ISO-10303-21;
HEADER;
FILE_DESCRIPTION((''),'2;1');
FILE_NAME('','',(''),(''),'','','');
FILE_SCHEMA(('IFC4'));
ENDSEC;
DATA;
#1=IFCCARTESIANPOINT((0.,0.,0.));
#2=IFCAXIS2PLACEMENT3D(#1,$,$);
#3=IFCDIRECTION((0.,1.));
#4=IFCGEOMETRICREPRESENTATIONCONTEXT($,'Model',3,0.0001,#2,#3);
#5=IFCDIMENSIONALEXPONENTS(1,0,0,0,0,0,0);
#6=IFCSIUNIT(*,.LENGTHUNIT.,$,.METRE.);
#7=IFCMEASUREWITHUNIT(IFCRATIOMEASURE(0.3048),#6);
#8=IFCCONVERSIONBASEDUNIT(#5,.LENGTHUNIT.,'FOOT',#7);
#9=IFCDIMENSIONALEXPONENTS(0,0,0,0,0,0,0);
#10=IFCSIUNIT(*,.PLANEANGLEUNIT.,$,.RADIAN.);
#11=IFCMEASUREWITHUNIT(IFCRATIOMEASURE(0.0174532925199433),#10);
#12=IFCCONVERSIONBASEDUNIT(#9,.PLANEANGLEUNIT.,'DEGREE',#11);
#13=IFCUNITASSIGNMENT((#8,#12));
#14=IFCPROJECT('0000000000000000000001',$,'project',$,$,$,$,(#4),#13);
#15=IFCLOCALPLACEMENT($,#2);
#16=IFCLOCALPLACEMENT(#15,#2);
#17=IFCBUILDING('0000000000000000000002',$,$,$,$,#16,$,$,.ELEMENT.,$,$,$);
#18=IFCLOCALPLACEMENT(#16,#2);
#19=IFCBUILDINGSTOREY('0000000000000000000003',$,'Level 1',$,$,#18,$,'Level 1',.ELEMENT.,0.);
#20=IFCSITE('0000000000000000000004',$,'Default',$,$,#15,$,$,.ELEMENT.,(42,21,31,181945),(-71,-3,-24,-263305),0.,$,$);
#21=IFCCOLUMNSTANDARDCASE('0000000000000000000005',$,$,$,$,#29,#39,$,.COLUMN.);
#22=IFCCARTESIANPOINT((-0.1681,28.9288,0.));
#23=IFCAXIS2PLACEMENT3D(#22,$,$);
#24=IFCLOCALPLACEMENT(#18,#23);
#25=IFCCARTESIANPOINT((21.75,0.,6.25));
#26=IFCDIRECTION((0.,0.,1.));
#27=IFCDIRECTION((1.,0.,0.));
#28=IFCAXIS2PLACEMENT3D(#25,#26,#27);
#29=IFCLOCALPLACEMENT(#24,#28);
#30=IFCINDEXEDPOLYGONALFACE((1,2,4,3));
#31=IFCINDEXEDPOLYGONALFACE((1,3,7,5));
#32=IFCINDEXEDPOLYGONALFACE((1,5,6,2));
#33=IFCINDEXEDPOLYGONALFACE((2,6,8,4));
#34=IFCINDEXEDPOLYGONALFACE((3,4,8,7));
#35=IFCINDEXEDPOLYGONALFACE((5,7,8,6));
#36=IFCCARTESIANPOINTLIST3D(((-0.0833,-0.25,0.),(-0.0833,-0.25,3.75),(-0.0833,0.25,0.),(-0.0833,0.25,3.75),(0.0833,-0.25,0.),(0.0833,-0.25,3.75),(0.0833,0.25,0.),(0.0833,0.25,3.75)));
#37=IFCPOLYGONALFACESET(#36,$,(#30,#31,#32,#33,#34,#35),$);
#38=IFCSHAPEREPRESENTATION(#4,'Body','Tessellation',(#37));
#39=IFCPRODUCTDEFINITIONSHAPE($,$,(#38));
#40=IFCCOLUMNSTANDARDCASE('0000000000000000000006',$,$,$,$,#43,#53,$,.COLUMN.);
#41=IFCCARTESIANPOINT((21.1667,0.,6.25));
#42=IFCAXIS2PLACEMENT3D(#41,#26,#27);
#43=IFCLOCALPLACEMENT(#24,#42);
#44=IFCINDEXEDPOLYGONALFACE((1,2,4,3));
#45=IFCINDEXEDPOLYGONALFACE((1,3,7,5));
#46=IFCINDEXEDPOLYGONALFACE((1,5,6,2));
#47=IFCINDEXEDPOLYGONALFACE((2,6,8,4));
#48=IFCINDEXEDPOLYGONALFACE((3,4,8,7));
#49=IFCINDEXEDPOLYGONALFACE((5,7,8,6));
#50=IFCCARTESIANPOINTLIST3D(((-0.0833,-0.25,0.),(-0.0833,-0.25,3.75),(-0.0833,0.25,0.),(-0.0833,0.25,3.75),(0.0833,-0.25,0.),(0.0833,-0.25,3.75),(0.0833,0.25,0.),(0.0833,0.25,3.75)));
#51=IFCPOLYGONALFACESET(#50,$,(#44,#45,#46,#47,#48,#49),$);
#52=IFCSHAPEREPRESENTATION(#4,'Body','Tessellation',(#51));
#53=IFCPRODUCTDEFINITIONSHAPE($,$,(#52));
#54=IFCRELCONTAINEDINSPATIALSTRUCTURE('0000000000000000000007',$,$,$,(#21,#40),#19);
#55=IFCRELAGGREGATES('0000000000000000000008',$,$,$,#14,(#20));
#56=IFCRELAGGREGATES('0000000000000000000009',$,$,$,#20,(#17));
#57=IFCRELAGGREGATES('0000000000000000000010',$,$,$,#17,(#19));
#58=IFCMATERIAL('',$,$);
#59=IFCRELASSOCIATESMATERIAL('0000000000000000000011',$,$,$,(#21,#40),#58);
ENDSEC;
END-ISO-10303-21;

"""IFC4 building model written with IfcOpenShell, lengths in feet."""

from ifc_helpers import new_model, entity, si_unit, converted_unit, direction, frame, origin, place, context, project, spatial, rectangle, extrude, material, element, save


model = new_model("IFC4")

# Units and contexts
model_context = context("Model", 3, precision=0.0001, world=origin(), true_north=direction((0.0, 1.0)))
ifc_project = project(units=[converted_unit("LENGTHUNIT", "FOOT", entity("IfcRatioMeasure", 0.3048), si_unit("LENGTHUNIT", "METRE"), dimensions=[1, 0, 0, 0, 0, 0, 0]), converted_unit("PLANEANGLEUNIT", "DEGREE", entity("IfcRatioMeasure", 0.0174532925199433), si_unit("PLANEANGLEUNIT", "RADIAN"), dimensions=[0, 0, 0, 0, 0, 0, 0])], contexts=[model_context])

# Site, building, storey
site_placement = place(None, origin())
site = spatial("IfcSite", under=ifc_project, at=site_placement, Name="Default", CompositionType="ELEMENT", RefLatitude=(42, 21, 31, 181945), RefLongitude=(-71, -3, -24, -263305), RefElevation=0.0)
building_placement = place(site_placement, origin())
building = spatial("IfcBuilding", under=site, at=building_placement, CompositionType="ELEMENT")
storey_placement = place(building_placement, origin())
storey = spatial("IfcBuildingStorey", under=building, at=storey_placement, Name="Level 1", LongName="Level 1", CompositionType="ELEMENT", Elevation=0.0)

# Columns
ifc_material = material(Name="")
placement = place(storey_placement, frame((-0.1681, 28.9288, 0.0)))
for number, where, z_axis, x_axis in (
    (1, (21.75, 0.0, 6.25), (0.0, 0.0, 1.0), (1.0, 0.0, 0.0)),
    (2, (21.1667, 0.0, 6.25), (0.0, 0.0, 1.0), (1.0, 0.0, 0.0)),
):
    element("IfcColumnStandardCase", number, at=place(placement, frame(where, z_axis=z_axis, x_axis=x_axis)), inside=storey, material=ifc_material, PredefinedType="COLUMN", context=model_context, shape_type="SweptSolid", body=[
        extrude(rectangle(XDim=0.1667, YDim=0.5), origin(), (0.0, 0.0, 1.0), 3.75),
    ])

save(model, "model.ifc")
